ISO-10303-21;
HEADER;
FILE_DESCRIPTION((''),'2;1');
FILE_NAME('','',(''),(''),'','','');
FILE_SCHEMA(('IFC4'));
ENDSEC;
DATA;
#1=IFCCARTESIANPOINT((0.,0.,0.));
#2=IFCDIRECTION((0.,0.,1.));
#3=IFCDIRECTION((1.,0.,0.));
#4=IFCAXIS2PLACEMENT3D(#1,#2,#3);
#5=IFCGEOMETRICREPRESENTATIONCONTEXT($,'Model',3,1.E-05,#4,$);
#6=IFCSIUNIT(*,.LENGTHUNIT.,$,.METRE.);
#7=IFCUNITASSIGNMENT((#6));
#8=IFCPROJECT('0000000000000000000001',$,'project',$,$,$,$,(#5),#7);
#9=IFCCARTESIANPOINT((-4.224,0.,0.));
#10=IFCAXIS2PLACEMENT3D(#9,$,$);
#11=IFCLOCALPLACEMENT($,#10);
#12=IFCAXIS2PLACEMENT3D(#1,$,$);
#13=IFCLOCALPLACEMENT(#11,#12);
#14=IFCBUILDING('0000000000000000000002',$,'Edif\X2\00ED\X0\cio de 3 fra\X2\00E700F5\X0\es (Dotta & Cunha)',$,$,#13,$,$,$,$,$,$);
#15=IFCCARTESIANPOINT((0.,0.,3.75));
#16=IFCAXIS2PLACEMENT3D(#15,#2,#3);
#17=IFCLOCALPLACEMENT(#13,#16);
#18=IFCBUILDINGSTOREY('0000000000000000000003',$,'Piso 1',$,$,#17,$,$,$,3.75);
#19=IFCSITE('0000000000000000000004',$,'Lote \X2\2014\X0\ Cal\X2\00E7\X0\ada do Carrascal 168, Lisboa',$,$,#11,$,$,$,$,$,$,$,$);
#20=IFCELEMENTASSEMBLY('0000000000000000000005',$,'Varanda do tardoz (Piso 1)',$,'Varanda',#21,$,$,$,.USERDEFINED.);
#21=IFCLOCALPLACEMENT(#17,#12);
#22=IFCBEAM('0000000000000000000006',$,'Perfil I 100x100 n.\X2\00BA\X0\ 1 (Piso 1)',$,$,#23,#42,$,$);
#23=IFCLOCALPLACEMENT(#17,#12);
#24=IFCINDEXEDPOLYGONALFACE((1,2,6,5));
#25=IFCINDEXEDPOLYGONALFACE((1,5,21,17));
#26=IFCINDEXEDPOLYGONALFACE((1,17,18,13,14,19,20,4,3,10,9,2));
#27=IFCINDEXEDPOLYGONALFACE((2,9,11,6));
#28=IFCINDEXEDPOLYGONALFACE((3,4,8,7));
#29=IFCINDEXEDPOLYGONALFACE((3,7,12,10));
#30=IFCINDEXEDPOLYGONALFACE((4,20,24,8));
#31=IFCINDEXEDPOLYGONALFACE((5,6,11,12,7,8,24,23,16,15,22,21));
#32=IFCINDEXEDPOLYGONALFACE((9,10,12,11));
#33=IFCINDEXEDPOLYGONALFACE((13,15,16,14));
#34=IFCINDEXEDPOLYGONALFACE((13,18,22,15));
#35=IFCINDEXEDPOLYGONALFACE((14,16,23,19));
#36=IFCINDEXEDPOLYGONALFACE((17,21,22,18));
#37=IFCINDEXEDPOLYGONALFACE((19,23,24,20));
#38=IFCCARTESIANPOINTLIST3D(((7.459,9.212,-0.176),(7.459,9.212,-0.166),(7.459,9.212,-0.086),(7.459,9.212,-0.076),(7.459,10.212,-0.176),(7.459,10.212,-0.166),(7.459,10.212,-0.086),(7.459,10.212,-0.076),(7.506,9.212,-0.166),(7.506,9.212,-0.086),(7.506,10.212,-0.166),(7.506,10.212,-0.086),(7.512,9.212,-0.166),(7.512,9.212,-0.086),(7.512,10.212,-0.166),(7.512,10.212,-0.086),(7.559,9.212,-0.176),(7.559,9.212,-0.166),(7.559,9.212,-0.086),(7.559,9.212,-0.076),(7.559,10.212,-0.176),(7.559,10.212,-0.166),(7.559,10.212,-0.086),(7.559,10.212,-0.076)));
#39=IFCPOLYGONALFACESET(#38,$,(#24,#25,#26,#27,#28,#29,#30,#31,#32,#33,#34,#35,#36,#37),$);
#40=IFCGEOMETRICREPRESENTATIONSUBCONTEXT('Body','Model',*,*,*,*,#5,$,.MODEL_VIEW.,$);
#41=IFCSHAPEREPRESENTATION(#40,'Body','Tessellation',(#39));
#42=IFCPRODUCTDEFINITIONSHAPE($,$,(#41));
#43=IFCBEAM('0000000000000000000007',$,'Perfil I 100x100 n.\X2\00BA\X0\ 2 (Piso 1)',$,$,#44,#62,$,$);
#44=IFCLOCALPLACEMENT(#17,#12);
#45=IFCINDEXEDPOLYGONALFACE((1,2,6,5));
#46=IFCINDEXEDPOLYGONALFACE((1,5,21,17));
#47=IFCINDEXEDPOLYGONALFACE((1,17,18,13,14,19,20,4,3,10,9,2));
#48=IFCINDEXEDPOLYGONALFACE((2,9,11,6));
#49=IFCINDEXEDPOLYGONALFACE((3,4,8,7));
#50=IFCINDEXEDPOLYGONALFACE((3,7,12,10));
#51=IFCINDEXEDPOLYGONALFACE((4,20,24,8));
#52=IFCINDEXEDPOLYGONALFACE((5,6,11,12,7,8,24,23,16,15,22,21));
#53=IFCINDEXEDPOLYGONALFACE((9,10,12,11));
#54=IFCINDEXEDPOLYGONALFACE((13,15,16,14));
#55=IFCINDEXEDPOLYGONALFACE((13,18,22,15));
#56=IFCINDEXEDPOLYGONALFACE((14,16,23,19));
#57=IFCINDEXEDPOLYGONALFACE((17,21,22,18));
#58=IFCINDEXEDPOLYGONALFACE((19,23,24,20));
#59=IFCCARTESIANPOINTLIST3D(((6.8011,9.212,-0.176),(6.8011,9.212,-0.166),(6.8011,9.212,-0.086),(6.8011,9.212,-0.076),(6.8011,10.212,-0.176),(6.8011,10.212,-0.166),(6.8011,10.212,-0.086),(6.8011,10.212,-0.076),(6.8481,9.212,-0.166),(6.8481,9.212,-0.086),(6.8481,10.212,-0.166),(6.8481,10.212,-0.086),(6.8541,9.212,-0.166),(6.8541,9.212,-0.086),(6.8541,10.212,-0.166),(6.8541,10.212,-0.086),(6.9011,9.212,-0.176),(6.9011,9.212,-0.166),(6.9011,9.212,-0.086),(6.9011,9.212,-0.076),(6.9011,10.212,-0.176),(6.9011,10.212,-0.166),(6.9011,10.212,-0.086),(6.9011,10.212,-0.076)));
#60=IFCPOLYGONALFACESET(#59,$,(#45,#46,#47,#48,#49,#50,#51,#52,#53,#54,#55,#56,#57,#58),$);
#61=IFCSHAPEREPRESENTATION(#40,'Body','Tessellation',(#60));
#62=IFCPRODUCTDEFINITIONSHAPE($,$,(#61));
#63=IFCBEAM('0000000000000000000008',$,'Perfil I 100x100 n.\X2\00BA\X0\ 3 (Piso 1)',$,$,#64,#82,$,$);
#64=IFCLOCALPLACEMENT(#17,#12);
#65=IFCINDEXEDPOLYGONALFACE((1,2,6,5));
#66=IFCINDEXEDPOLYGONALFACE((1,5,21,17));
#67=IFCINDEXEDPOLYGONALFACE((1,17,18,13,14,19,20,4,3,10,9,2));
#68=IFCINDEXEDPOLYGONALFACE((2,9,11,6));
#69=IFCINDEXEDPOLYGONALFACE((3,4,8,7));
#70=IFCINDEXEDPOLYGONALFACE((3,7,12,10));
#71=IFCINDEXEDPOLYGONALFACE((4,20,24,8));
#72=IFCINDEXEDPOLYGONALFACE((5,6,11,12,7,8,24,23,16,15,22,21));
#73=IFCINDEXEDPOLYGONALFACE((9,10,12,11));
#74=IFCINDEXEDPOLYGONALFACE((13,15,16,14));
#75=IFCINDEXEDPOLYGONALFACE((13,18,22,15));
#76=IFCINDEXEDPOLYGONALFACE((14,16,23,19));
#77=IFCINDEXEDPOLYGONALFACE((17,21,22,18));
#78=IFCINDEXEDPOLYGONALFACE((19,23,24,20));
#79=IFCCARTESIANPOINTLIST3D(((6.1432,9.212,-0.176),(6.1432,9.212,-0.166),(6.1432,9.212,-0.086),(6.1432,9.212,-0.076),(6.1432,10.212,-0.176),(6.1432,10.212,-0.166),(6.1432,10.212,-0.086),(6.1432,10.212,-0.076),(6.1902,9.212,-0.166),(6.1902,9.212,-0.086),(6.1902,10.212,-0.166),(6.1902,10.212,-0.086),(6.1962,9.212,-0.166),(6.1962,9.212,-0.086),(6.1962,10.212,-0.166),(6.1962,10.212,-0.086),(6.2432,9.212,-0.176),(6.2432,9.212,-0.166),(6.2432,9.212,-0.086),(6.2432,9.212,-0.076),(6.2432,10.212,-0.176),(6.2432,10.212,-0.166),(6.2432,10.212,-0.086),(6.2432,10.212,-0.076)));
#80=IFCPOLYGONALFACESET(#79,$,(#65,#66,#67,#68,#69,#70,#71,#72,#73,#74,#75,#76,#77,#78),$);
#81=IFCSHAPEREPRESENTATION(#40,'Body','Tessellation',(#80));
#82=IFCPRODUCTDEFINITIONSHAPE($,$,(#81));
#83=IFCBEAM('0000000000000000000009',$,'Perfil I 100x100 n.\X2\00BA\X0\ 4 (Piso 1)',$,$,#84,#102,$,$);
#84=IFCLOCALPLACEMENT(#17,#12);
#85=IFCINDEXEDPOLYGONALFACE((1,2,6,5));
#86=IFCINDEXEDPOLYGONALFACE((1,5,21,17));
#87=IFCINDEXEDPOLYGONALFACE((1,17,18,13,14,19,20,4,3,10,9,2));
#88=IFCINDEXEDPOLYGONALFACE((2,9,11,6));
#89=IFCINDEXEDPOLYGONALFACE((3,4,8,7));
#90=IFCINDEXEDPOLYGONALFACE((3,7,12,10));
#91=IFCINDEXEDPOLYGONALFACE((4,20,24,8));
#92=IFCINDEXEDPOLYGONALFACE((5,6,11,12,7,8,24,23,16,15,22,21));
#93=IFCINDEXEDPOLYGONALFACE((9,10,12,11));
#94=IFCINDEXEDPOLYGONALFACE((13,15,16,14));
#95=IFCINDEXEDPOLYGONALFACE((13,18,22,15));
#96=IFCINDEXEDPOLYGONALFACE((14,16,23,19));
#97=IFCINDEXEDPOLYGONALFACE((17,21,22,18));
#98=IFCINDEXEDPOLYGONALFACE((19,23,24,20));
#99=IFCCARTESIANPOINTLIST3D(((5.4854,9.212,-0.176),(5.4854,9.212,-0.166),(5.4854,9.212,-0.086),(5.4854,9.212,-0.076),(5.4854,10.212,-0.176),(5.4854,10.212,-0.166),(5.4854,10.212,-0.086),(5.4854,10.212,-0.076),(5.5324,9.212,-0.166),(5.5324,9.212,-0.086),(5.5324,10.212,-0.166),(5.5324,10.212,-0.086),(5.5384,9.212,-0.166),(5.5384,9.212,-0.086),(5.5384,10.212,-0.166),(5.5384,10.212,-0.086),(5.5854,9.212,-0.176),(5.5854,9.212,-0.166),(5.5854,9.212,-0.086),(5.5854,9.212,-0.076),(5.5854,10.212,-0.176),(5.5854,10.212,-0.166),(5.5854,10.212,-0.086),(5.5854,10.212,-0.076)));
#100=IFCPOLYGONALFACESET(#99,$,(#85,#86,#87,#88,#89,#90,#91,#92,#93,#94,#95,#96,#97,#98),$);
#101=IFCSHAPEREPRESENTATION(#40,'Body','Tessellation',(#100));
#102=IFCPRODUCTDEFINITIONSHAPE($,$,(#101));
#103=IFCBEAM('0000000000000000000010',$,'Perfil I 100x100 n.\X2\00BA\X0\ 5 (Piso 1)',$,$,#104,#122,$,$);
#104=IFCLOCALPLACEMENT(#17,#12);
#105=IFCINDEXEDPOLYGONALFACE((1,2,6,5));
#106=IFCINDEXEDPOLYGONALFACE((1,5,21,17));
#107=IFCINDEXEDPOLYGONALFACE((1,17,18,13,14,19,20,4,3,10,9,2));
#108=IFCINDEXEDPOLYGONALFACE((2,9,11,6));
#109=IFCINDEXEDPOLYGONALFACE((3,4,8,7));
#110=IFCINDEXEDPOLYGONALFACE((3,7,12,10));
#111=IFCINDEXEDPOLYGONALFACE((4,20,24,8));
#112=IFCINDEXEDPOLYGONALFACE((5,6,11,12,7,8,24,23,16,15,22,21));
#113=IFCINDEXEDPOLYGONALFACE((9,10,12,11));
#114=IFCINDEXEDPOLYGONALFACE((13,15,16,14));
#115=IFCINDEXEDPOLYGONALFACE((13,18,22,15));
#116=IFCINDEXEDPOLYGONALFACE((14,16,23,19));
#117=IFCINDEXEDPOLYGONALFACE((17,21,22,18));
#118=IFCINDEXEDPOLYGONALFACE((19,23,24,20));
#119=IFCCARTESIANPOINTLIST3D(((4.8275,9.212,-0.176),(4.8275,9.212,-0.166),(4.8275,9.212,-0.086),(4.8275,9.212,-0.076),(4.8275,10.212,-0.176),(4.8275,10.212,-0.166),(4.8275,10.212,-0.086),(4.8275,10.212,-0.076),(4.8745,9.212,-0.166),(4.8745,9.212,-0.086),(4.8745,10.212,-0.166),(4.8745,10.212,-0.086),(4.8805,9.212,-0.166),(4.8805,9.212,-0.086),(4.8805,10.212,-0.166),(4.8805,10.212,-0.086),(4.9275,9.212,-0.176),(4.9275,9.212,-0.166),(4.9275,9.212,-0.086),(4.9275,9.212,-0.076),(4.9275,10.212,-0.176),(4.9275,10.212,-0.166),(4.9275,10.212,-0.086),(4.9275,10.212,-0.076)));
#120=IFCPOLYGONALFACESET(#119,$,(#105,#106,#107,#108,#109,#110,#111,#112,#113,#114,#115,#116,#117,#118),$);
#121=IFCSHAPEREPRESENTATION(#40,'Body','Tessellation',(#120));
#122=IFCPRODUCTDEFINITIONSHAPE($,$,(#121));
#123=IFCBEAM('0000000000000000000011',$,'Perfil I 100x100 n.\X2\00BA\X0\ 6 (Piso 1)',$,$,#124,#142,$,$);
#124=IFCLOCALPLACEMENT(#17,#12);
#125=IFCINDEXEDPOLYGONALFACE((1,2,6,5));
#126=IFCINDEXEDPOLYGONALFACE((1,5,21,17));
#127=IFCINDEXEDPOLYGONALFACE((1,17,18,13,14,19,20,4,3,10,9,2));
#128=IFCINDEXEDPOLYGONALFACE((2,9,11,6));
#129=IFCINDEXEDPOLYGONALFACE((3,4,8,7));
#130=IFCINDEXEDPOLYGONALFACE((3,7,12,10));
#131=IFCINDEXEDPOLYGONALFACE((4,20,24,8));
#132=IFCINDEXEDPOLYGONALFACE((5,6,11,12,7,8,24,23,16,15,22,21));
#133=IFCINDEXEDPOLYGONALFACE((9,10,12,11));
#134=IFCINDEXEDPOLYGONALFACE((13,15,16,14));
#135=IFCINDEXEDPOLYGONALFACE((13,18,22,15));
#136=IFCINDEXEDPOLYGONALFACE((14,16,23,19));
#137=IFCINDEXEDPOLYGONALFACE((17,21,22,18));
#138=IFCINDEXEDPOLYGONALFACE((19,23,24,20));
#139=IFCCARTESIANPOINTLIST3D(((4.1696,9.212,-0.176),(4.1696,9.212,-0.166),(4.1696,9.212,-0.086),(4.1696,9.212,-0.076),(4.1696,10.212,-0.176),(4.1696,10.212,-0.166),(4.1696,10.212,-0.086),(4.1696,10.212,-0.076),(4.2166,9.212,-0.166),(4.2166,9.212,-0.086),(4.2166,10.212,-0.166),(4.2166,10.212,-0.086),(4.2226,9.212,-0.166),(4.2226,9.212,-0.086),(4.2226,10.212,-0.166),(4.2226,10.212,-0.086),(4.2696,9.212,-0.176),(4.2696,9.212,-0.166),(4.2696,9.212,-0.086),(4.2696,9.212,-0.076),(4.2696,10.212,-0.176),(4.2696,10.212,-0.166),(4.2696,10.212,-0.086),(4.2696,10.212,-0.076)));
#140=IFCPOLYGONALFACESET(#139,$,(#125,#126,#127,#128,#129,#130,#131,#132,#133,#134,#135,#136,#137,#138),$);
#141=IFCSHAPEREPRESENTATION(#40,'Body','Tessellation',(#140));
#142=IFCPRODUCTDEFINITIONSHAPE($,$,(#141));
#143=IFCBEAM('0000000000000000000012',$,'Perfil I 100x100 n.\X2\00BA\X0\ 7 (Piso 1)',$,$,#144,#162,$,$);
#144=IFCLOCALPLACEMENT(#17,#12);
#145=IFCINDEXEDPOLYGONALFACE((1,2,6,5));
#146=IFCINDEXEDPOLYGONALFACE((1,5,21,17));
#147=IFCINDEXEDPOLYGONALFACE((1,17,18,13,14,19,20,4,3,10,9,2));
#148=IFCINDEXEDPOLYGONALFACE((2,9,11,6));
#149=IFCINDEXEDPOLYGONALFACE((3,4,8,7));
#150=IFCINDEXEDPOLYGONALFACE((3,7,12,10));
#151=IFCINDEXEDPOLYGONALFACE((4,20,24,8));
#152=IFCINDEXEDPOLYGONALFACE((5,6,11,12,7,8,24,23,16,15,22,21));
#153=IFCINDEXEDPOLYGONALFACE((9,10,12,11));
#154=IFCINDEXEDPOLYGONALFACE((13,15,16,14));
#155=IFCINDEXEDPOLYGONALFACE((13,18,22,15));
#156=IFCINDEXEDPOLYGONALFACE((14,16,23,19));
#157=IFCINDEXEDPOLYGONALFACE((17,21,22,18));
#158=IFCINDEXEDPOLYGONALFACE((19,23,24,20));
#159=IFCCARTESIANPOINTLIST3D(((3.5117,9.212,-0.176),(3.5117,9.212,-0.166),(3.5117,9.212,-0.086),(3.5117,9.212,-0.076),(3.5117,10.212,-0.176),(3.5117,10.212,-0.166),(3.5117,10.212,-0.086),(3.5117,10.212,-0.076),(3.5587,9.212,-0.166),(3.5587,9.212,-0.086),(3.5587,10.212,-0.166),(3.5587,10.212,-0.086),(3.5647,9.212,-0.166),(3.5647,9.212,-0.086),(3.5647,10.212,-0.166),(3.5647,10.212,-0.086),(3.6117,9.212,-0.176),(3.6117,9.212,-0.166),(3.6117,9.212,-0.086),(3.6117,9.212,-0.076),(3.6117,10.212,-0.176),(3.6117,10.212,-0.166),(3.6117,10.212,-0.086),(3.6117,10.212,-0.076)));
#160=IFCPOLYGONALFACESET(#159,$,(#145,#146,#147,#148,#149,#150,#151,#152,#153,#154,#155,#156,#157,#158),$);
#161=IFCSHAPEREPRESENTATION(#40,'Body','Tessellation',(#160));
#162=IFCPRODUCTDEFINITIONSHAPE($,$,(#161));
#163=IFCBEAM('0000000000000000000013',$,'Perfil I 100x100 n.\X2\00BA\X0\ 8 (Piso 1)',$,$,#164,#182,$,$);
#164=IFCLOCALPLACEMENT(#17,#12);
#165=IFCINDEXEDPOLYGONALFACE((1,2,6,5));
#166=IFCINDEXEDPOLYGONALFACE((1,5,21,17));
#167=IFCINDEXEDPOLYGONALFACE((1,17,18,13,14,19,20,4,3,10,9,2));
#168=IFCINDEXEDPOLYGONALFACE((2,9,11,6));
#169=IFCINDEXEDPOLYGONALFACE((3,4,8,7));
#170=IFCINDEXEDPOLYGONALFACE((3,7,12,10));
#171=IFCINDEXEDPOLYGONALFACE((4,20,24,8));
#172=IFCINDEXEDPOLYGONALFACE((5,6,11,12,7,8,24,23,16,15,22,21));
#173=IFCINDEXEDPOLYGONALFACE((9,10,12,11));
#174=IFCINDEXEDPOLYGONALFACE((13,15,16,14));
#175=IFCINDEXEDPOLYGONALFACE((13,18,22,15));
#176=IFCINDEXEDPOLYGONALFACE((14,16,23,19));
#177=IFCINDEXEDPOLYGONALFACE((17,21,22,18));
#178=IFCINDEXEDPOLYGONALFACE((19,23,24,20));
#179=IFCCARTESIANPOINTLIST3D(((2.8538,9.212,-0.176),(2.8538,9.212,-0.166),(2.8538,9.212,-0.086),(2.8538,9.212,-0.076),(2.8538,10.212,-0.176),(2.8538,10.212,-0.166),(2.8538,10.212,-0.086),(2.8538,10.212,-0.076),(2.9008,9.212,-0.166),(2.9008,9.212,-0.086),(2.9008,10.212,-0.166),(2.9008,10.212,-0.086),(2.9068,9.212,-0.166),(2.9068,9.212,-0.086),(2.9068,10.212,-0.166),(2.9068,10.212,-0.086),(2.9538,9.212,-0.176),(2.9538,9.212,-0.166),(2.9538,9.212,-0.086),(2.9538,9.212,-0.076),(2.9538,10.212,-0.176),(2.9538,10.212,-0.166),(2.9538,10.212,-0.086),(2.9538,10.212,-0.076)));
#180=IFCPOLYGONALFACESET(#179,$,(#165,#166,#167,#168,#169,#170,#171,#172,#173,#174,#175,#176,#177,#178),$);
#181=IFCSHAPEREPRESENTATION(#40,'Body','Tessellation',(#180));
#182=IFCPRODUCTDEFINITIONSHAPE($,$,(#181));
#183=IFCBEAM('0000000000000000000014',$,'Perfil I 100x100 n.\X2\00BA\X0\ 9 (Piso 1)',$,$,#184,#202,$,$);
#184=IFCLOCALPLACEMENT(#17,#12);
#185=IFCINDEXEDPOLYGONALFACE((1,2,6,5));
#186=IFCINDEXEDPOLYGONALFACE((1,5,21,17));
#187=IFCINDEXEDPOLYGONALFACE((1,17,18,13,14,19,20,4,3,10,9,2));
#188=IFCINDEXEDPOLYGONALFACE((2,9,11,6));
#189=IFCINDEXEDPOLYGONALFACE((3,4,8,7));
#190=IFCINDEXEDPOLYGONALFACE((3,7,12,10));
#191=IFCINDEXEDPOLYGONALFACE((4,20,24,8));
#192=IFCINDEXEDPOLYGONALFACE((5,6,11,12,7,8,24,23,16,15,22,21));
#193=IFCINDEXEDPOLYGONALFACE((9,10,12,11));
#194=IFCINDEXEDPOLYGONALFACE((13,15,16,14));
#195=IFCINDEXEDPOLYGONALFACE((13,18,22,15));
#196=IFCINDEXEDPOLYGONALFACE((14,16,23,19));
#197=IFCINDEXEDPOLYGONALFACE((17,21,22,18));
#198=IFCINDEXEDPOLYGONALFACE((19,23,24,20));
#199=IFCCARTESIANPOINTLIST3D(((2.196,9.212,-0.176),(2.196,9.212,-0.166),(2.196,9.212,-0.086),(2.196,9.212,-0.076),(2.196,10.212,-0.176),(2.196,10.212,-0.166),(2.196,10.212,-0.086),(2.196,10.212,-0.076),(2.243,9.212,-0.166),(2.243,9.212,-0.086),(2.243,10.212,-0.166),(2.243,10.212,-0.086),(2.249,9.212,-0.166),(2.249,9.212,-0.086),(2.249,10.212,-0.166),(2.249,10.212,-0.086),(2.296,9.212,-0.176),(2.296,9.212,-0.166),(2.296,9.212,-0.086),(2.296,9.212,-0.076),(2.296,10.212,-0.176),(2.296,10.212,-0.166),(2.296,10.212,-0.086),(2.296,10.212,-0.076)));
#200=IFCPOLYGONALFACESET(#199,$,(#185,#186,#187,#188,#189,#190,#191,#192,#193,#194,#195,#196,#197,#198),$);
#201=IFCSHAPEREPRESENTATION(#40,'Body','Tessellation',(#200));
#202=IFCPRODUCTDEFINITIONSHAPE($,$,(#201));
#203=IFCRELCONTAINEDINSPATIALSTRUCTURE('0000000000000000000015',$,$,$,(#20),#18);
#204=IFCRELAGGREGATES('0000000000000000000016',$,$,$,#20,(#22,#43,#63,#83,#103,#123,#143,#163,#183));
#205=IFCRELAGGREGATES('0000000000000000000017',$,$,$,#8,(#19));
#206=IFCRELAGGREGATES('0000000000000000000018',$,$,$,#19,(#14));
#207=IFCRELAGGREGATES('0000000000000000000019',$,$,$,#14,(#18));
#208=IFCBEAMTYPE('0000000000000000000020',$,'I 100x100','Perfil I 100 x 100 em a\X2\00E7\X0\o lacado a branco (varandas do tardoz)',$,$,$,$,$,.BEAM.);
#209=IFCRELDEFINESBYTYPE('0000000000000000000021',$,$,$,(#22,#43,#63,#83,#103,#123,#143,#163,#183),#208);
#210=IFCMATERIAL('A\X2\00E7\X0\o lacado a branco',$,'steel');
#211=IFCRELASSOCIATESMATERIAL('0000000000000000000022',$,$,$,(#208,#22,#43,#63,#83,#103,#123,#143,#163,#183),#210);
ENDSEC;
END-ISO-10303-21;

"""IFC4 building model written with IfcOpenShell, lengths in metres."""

from ifc_helpers import new_model, si_unit, frame, origin, origin_with_axes, place, context, subcontext, project, spatial, i_section, extrude, material, type_object, element, aggregate, save


model = new_model("IFC4")

# Units and contexts
model_context = context("Model", 3, precision=1e-05, world=origin_with_axes())
body_context = subcontext(model_context, "Body", "Model", "MODEL_VIEW")
ifc_project = project(units=[si_unit("LENGTHUNIT", "METRE")], contexts=[model_context])

# Site, building, storey
site_placement = place(None, frame((-4.224, 0.0, 0.0)))
site = spatial("IfcSite", under=ifc_project, at=site_placement, Name="Lote — Calçada do Carrascal 168, Lisboa")
building_placement = place(site_placement, origin())
building = spatial("IfcBuilding", under=site, at=building_placement, Name="Edifício de 3 frações (Dotta & Cunha)")
storey_placement = place(building_placement, frame((0.0, 0.0, 3.75), z_axis=(0.0, 0.0, 1.0), x_axis=(1.0, 0.0, 0.0)))
storey = spatial("IfcBuildingStorey", under=building, at=storey_placement, Name="Piso 1", Elevation=3.75)

# Element assembly, beams
assembly_1 = element("IfcElementAssembly", 1, inside=storey, Name="Varanda do tardoz (Piso 1)", ObjectType="Varanda", PredefinedType="USERDEFINED")
ifc_material_1 = material(Name="Aço lacado a branco", Category="steel")
beam_type = type_object("IfcBeamType", Name="I 100x100", Description="Perfil I 100 x 100 em aço lacado a branco (varandas do tardoz)", PredefinedType="BEAM", material=ifc_material_1)
beam_1_placement = place(building_placement, origin_with_axes())
beam_1 = element("IfcBeam", 2, at=beam_1_placement, type_object=beam_type, material=ifc_material_1, Name="Perfil I 100x100 n.º 1 (Piso 1)", context=body_context, shape_type="SweptSolid", body=[
    extrude(i_section(OverallWidth=0.1, OverallDepth=0.1, WebThickness=0.006, FlangeThickness=0.01), frame((7.509, 9.212, 3.624), z_axis=(0.0, 1.0, 0.0), x_axis=(-1.0, 0.0, 0.0)), (0.0, 0.0, 1.0), 1.0),
])
beam_2_placement = place(building_placement, origin_with_axes())
beam_2 = element("IfcBeam", 3, at=beam_2_placement, type_object=beam_type, material=ifc_material_1, Name="Perfil I 100x100 n.º 2 (Piso 1)", context=body_context, shape_type="SweptSolid", body=[
    extrude(i_section(OverallWidth=0.1, OverallDepth=0.1, WebThickness=0.006, FlangeThickness=0.01), frame((6.8511, 9.212, 3.624), z_axis=(0.0, 1.0, 0.0), x_axis=(-1.0, 0.0, 0.0)), (0.0, 0.0, 1.0), 1.0),
])
beam_3_placement = place(building_placement, origin_with_axes())
beam_3 = element("IfcBeam", 4, at=beam_3_placement, type_object=beam_type, material=ifc_material_1, Name="Perfil I 100x100 n.º 3 (Piso 1)", context=body_context, shape_type="SweptSolid", body=[
    extrude(i_section(OverallWidth=0.1, OverallDepth=0.1, WebThickness=0.006, FlangeThickness=0.01), frame((6.1932, 9.212, 3.624), z_axis=(0.0, 1.0, 0.0), x_axis=(-1.0, 0.0, 0.0)), (0.0, 0.0, 1.0), 1.0),
])
beam_4_placement = place(building_placement, origin_with_axes())
beam_4 = element("IfcBeam", 5, at=beam_4_placement, type_object=beam_type, material=ifc_material_1, Name="Perfil I 100x100 n.º 4 (Piso 1)", context=body_context, shape_type="SweptSolid", body=[
    extrude(i_section(OverallWidth=0.1, OverallDepth=0.1, WebThickness=0.006, FlangeThickness=0.01), frame((5.5354, 9.212, 3.624), z_axis=(0.0, 1.0, 0.0), x_axis=(-1.0, 0.0, 0.0)), (0.0, 0.0, 1.0), 1.0),
])
beam_5_placement = place(building_placement, origin_with_axes())
beam_5 = element("IfcBeam", 6, at=beam_5_placement, type_object=beam_type, material=ifc_material_1, Name="Perfil I 100x100 n.º 5 (Piso 1)", context=body_context, shape_type="SweptSolid", body=[
    extrude(i_section(OverallWidth=0.1, OverallDepth=0.1, WebThickness=0.006, FlangeThickness=0.01), frame((4.8775, 9.212, 3.624), z_axis=(0.0, 1.0, 0.0), x_axis=(-1.0, 0.0, 0.0)), (0.0, 0.0, 1.0), 1.0),
])
beam_6_placement = place(building_placement, origin_with_axes())
beam_6 = element("IfcBeam", 7, at=beam_6_placement, type_object=beam_type, material=ifc_material_1, Name="Perfil I 100x100 n.º 6 (Piso 1)", context=body_context, shape_type="SweptSolid", body=[
    extrude(i_section(OverallWidth=0.1, OverallDepth=0.1, WebThickness=0.006, FlangeThickness=0.01), frame((4.2196, 9.212, 3.624), z_axis=(0.0, 1.0, 0.0), x_axis=(-1.0, 0.0, 0.0)), (0.0, 0.0, 1.0), 1.0),
])
beam_7_placement = place(building_placement, origin_with_axes())
beam_7 = element("IfcBeam", 8, at=beam_7_placement, type_object=beam_type, material=ifc_material_1, Name="Perfil I 100x100 n.º 7 (Piso 1)", context=body_context, shape_type="SweptSolid", body=[
    extrude(i_section(OverallWidth=0.1, OverallDepth=0.1, WebThickness=0.006, FlangeThickness=0.01), frame((3.5617, 9.212, 3.624), z_axis=(0.0, 1.0, 0.0), x_axis=(-1.0, 0.0, 0.0)), (0.0, 0.0, 1.0), 1.0),
])
beam_8_placement = place(building_placement, origin_with_axes())
beam_8 = element("IfcBeam", 9, at=beam_8_placement, type_object=beam_type, material=ifc_material_1, Name="Perfil I 100x100 n.º 8 (Piso 1)", context=body_context, shape_type="SweptSolid", body=[
    extrude(i_section(OverallWidth=0.1, OverallDepth=0.1, WebThickness=0.006, FlangeThickness=0.01), frame((2.9038, 9.212, 3.624), z_axis=(0.0, 1.0, 0.0), x_axis=(-1.0, 0.0, 0.0)), (0.0, 0.0, 1.0), 1.0),
])
beam_9_placement = place(building_placement, origin_with_axes())
beam_9 = element("IfcBeam", 10, at=beam_9_placement, type_object=beam_type, material=ifc_material_1, Name="Perfil I 100x100 n.º 9 (Piso 1)", context=body_context, shape_type="SweptSolid", body=[
    extrude(i_section(OverallWidth=0.1, OverallDepth=0.1, WebThickness=0.006, FlangeThickness=0.01), frame((2.246, 9.212, 3.624), z_axis=(0.0, 1.0, 0.0), x_axis=(-1.0, 0.0, 0.0)), (0.0, 0.0, 1.0), 1.0),
])

aggregate(assembly_1, [beam_1, beam_2, beam_3, beam_4, beam_5, beam_6, beam_7, beam_8, beam_9])

save(model, "model.ifc")
